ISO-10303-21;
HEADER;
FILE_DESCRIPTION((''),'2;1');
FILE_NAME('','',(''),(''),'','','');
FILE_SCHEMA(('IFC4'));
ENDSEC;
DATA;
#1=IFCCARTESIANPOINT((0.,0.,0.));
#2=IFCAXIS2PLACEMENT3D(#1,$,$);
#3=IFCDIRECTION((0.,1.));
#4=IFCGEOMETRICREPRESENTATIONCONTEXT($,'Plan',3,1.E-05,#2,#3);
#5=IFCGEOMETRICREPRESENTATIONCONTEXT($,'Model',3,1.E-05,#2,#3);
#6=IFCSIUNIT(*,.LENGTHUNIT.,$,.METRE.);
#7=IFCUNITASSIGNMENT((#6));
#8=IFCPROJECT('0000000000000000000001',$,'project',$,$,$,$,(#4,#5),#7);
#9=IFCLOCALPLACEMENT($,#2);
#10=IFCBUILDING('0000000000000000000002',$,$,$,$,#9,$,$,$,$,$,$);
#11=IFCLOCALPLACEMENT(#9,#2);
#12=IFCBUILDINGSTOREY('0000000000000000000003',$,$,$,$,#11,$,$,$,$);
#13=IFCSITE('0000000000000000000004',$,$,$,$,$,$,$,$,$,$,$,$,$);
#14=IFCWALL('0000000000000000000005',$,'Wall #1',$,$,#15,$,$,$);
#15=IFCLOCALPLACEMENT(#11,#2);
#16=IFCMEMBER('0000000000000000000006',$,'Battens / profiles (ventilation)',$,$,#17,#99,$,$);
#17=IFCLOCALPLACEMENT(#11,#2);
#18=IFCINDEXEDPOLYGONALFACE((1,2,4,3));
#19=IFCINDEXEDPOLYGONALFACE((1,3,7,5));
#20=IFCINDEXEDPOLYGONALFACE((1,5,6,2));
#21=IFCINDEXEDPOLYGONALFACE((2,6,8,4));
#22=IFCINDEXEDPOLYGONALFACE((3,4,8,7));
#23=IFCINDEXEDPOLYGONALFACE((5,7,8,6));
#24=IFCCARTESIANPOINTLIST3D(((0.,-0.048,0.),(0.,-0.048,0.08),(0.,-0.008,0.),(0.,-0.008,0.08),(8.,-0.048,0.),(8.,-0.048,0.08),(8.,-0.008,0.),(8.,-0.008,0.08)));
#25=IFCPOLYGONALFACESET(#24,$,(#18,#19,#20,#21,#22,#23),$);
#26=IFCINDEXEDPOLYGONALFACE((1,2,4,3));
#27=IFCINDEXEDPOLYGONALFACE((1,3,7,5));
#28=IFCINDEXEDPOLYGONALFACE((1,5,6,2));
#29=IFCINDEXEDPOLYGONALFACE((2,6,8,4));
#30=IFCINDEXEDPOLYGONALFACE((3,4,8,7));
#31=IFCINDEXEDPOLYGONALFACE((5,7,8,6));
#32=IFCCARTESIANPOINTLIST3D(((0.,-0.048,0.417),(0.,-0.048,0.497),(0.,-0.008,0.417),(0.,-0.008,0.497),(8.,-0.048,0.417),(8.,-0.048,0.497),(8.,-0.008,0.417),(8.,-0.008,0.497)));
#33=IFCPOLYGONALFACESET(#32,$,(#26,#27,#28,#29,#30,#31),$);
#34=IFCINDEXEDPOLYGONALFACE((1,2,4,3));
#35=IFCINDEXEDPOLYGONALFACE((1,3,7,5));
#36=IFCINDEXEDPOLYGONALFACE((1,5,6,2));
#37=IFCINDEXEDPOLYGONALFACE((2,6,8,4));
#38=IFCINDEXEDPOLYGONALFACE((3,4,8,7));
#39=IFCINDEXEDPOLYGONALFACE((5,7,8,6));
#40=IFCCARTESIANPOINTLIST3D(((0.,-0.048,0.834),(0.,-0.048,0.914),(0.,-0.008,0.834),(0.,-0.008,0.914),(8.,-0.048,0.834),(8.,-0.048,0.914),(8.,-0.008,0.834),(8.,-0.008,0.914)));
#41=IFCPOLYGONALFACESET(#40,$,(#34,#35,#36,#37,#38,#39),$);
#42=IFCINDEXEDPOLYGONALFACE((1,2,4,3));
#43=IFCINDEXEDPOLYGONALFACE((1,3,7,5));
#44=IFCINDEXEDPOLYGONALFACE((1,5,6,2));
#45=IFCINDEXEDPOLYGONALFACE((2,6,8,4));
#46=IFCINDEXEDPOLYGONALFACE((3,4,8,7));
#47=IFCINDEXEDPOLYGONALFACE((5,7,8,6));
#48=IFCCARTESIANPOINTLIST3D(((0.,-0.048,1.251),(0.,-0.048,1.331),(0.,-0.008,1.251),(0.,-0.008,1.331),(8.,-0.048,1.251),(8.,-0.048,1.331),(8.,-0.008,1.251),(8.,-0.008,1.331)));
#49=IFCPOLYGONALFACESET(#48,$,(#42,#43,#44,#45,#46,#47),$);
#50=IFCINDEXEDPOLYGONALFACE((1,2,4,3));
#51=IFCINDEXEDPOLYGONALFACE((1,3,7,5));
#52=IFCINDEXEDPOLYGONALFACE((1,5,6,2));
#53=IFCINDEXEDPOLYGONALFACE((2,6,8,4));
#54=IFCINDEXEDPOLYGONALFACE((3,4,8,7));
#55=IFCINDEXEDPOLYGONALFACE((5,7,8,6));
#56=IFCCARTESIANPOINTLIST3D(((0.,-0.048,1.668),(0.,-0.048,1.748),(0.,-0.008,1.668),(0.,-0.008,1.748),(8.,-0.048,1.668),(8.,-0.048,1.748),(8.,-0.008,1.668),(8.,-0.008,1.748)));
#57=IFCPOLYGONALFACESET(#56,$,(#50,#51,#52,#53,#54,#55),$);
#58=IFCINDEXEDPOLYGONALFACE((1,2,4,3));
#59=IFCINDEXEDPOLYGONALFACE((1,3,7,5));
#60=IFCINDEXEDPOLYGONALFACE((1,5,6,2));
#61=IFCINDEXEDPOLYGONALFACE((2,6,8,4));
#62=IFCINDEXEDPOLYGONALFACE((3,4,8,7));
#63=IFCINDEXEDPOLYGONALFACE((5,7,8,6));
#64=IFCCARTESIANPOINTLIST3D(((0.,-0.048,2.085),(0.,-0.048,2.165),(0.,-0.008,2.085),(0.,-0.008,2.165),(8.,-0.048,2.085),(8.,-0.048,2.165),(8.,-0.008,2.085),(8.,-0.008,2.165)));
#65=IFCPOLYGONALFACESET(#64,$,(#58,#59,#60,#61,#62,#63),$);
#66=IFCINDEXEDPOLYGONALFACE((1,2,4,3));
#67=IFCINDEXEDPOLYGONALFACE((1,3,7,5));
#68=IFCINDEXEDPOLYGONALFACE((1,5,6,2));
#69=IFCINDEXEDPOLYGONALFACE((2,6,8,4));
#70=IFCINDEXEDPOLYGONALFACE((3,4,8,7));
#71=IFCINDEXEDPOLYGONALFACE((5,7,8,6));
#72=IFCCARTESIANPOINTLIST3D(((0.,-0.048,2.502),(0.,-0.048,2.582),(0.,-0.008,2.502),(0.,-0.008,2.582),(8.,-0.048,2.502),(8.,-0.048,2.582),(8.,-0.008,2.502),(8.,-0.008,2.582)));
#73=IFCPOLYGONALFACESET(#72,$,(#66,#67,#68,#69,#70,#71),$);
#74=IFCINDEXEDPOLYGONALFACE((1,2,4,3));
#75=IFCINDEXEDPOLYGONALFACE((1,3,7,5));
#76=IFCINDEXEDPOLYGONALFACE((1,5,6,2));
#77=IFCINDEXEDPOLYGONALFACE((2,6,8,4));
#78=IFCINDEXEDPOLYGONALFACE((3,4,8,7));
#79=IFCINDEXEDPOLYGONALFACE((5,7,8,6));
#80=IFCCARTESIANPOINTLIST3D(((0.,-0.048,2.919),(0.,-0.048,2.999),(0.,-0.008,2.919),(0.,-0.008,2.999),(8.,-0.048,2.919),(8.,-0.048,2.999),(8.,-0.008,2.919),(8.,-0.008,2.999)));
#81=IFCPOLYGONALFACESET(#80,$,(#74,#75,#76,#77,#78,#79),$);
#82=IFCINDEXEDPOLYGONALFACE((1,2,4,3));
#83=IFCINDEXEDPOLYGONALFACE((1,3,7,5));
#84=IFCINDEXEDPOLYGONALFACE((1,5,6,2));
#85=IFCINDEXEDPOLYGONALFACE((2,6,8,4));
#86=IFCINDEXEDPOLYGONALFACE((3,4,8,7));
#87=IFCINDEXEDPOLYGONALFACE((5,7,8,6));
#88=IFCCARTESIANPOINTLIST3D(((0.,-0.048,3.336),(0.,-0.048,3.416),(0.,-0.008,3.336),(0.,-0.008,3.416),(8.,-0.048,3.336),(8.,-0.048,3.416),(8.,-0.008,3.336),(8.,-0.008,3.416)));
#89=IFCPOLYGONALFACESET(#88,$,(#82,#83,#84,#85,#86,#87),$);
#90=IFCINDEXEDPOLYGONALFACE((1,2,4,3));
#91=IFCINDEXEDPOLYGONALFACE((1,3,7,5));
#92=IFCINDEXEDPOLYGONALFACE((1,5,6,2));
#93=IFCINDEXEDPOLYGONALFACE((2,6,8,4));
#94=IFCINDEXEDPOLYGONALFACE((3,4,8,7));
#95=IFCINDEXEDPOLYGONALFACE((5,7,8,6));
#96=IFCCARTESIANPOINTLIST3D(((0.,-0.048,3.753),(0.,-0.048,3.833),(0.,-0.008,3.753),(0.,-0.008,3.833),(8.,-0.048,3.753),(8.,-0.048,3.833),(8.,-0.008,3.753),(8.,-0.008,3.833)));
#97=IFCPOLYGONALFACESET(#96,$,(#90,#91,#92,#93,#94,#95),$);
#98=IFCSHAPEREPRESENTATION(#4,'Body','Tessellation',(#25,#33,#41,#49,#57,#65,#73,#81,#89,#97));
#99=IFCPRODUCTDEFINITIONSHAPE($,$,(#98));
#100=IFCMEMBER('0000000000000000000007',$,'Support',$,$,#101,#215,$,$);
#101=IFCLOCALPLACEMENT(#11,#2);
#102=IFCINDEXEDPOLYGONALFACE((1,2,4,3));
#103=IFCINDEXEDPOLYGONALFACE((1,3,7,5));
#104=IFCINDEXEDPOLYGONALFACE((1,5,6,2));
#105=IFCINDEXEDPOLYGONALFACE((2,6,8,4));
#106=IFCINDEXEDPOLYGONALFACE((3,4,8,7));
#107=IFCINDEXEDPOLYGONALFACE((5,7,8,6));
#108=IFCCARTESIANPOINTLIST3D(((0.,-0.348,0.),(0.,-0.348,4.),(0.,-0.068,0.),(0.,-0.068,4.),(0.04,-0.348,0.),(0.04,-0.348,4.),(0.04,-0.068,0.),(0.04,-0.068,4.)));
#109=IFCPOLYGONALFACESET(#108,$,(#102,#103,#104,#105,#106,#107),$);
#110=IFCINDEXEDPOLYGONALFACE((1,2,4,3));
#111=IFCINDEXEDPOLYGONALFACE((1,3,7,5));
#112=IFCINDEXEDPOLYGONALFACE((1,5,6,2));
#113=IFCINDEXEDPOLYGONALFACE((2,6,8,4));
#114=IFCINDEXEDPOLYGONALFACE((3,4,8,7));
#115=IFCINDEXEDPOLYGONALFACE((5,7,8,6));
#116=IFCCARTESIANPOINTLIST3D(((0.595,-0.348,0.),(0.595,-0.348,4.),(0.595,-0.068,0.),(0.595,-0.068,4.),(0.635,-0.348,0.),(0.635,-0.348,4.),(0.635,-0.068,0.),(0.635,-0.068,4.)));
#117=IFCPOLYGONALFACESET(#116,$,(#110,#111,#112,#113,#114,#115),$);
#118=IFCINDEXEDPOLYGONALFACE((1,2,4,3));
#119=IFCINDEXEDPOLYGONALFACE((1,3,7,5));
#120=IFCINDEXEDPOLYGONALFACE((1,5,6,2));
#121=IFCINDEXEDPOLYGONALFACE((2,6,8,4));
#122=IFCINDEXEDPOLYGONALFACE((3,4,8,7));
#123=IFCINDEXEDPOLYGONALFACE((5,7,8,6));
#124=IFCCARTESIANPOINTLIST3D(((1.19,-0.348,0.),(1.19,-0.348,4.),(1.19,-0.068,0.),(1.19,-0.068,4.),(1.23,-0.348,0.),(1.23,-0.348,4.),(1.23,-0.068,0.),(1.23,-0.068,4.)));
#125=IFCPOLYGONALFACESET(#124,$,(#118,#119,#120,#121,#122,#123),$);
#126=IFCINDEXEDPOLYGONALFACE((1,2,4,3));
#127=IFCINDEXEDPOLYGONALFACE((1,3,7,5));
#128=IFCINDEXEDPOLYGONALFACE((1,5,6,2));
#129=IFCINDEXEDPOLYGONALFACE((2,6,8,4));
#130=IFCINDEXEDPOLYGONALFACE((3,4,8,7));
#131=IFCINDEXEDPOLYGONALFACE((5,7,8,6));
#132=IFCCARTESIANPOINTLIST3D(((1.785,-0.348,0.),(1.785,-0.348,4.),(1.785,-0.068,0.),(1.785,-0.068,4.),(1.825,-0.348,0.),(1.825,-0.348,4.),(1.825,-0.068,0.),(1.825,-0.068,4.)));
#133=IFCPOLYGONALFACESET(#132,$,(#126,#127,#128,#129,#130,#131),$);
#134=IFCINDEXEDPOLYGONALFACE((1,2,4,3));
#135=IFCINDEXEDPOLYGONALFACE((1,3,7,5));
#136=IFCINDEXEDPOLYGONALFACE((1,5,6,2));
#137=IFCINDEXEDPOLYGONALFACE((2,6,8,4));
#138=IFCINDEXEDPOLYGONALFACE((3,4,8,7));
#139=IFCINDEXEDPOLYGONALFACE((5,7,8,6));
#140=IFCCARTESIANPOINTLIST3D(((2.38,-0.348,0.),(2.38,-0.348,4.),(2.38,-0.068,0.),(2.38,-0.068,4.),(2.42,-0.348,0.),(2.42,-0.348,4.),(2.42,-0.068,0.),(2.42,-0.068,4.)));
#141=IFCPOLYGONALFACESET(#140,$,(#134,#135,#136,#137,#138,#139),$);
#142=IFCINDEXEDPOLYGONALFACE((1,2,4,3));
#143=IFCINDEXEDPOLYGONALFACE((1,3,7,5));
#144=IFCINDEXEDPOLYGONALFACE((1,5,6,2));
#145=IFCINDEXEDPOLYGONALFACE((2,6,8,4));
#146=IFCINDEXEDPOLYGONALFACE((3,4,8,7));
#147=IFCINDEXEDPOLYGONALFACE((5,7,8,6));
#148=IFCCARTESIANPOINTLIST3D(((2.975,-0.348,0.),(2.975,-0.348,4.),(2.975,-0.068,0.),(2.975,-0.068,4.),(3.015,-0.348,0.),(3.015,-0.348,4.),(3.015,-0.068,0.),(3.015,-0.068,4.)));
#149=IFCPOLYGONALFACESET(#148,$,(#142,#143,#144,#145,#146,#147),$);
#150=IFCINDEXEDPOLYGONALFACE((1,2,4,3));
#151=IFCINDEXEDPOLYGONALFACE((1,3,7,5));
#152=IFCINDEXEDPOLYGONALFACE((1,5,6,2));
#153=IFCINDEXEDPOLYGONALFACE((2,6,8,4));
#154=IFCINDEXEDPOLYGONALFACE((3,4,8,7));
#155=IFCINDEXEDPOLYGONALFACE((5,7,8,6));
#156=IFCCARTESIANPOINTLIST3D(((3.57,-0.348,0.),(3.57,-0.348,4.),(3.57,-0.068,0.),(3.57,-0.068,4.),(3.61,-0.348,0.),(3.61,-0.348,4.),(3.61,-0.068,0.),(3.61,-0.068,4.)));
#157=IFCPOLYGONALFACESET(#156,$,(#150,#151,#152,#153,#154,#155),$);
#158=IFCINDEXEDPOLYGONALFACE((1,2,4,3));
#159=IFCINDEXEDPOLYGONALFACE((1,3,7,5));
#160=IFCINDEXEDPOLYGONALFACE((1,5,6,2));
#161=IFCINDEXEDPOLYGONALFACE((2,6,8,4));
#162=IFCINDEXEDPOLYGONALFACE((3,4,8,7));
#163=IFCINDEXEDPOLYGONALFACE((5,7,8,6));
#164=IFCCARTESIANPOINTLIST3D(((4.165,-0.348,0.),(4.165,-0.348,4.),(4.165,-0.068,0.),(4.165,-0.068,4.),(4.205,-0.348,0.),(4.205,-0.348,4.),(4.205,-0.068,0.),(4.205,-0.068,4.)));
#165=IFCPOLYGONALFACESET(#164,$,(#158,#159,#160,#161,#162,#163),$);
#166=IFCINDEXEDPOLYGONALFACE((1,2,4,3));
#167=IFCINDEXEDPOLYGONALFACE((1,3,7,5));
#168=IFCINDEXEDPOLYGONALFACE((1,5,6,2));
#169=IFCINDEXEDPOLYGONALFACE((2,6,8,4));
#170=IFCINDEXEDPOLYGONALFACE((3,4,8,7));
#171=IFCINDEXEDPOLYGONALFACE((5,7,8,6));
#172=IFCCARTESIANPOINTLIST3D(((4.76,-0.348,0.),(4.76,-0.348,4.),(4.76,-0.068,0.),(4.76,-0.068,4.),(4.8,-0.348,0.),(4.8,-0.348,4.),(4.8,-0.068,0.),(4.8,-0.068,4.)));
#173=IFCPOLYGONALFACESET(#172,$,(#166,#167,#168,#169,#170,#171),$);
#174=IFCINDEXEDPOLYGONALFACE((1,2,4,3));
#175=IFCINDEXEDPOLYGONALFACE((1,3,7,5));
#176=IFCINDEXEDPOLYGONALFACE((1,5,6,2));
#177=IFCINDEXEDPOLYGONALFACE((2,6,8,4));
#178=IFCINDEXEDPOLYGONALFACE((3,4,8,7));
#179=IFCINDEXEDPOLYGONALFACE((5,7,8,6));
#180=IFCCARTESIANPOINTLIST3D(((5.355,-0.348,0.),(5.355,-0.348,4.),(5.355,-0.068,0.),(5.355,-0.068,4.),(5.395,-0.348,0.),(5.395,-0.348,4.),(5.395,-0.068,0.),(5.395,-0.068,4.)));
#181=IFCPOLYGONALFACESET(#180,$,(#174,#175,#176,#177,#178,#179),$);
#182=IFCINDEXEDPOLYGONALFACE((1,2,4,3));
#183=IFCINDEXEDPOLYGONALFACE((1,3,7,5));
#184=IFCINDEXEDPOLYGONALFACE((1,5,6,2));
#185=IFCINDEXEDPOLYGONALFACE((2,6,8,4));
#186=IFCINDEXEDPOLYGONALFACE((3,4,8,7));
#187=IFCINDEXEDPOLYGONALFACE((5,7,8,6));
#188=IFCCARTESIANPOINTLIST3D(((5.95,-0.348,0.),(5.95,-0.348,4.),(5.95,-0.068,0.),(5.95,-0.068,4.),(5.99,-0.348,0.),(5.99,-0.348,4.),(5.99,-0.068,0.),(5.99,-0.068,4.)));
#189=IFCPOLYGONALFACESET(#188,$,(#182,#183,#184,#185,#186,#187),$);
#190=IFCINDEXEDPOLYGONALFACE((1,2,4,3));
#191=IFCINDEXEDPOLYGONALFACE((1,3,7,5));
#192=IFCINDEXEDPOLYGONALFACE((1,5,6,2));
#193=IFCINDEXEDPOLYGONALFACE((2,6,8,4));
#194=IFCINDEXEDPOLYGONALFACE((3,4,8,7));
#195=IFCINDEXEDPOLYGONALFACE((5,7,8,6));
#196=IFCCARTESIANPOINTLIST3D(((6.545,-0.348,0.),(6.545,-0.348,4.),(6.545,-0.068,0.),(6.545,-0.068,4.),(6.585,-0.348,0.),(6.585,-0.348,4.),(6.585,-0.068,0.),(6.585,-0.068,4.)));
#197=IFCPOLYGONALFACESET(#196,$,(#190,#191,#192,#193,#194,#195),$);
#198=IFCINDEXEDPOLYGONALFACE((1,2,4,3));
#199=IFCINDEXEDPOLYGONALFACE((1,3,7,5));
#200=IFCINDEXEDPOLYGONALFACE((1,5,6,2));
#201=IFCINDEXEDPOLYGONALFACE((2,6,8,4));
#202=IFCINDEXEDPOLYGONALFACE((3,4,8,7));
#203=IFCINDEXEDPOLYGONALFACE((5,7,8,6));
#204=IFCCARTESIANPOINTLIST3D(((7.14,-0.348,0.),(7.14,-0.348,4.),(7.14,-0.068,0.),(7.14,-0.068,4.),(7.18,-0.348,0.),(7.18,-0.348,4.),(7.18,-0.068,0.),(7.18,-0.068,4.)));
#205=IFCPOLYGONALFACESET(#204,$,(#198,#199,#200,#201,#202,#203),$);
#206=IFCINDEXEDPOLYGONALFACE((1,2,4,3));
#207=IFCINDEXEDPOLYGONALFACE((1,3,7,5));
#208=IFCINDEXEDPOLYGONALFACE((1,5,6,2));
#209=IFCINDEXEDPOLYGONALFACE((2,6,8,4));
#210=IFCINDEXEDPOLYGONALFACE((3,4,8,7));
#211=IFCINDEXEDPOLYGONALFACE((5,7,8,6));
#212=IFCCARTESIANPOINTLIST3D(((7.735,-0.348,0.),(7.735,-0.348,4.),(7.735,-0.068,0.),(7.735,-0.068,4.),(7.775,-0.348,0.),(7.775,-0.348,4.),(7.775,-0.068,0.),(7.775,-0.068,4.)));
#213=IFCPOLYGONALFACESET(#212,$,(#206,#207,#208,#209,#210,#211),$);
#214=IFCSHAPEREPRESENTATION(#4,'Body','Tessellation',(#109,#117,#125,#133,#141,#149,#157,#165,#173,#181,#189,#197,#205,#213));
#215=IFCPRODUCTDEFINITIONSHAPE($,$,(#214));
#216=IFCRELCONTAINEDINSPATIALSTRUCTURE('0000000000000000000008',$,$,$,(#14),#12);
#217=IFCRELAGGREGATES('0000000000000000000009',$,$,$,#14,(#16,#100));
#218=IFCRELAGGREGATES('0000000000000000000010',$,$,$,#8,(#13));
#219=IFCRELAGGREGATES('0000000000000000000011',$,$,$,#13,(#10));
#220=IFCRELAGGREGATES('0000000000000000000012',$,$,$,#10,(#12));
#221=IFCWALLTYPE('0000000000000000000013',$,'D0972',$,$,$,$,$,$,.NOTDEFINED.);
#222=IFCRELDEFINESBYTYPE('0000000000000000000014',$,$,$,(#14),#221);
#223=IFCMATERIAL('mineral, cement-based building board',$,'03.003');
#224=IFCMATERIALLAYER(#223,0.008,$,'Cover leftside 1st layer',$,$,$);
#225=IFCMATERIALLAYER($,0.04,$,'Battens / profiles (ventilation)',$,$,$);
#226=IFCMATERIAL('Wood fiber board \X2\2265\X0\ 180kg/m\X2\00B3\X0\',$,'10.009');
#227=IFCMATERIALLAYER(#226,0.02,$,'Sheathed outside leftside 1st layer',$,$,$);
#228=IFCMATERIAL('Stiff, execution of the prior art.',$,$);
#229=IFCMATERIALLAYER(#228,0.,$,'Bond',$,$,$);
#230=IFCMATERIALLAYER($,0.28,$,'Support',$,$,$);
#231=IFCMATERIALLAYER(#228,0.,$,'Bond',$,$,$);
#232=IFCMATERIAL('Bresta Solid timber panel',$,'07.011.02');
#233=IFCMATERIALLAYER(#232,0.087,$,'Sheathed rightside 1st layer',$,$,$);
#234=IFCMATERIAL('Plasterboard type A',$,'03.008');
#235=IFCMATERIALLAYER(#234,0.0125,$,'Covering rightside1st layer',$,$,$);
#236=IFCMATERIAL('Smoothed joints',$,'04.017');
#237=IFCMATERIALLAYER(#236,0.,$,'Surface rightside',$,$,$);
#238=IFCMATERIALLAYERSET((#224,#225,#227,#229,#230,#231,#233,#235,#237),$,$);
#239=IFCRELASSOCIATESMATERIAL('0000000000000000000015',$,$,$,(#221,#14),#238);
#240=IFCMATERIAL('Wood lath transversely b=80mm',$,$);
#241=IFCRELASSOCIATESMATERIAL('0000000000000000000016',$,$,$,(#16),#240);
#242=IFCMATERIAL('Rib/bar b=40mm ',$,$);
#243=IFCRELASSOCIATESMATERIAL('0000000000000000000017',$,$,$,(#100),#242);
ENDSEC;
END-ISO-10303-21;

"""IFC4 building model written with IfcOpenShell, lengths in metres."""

from ifc_helpers import new_model, si_unit, direction, frame, frame_2d, origin, place, context, project, spatial, rectangle, extrude, material, layer, layer_set, type_object, element, aggregate, save


model = new_model("IFC4")

# Units and contexts
plan_context = context("Plan", 3, precision=1e-05, world=origin(), true_north=direction((0.0, 1.0)))
model_context = context("Model", 3, precision=1e-05, world=origin(), true_north=direction((0.0, 1.0)))
ifc_project = project(units=[si_unit("LENGTHUNIT", "METRE")], contexts=[plan_context, model_context])

# Site, building, storey
site = spatial("IfcSite", under=ifc_project)
building_placement = place(None, origin())
building = spatial("IfcBuilding", under=site, at=building_placement)
storey_placement = place(building_placement, origin())
storey = spatial("IfcBuildingStorey", under=building, at=storey_placement)

# Wall, members
ifc_material_1 = material(Name="mineral, cement-based building board", Category="03.003")
ifc_layer_1 = layer(ifc_material_1, 0.008, Name="Cover leftside 1st layer")
ifc_layer_2 = layer(None, 0.04, Name="Battens / profiles (ventilation)")
ifc_material_2 = material(Name="Wood fiber board ≥ 180kg/m³", Category="10.009")
ifc_layer_3 = layer(ifc_material_2, 0.02, Name="Sheathed outside leftside 1st layer")
ifc_material_3 = material(Name="Stiff, execution of the prior art.")
ifc_layer_4 = layer(ifc_material_3, 0.0, Name="Bond")
ifc_layer_5 = layer(None, 0.28, Name="Support")
ifc_layer_6 = layer(ifc_material_3, 0.0, Name="Bond")
ifc_material_4 = material(Name="Bresta Solid timber panel", Category="07.011.02")
ifc_layer_7 = layer(ifc_material_4, 0.087, Name="Sheathed rightside 1st layer")
ifc_material_5 = material(Name="Plasterboard type A", Category="03.008")
ifc_layer_8 = layer(ifc_material_5, 0.0125, Name="Covering rightside1st layer")
ifc_material_6 = material(Name="Smoothed joints", Category="04.017")
ifc_layer_9 = layer(ifc_material_6, 0.0, Name="Surface rightside")
ifc_layer_set = layer_set([ifc_layer_1, ifc_layer_2, ifc_layer_3, ifc_layer_4, ifc_layer_5, ifc_layer_6, ifc_layer_7, ifc_layer_8, ifc_layer_9])
wall_type = type_object("IfcWallType", Name="D0972", PredefinedType="NOTDEFINED", material=ifc_layer_set)
wall_placement = place(None, frame((0.0, 0.0, 0.0), z_axis=(0.0, -1.0, 0.0), x_axis=(1.0, 0.0, 0.0)))
wall = element("IfcWall", 1, at=wall_placement, inside=storey, type_object=wall_type, material=ifc_layer_set, Name="Wall #1")
ifc_material_7 = material(Name="Wood lath transversely b=80mm")
member_1_placement = place(wall_placement, origin())
member_1 = element("IfcMember", 2, at=member_1_placement, material=ifc_material_7, Name="Battens / profiles (ventilation)", context=plan_context, shape_type="SweptSolid", body=[
    extrude(rectangle(XDim=0.08, YDim=0.04, at=frame_2d((0.04, 0.02), x_axis=(1.0, 0.0))), frame((0.0, 0.0, 0.008), z_axis=(1.0, 0.0, 0.0), x_axis=(0.0, 1.0, 0.0)), (0.0, 0.0, 1.0), 8.0),
    extrude(rectangle(XDim=0.08, YDim=0.04, at=frame_2d((0.04, 0.02), x_axis=(1.0, 0.0))), frame((0.0, 0.417, 0.008), z_axis=(1.0, 0.0, 0.0), x_axis=(0.0, 1.0, 0.0)), (0.0, 0.0, 1.0), 8.0),
    extrude(rectangle(XDim=0.08, YDim=0.04, at=frame_2d((0.04, 0.02), x_axis=(1.0, 0.0))), frame((0.0, 0.834, 0.008), z_axis=(1.0, 0.0, 0.0), x_axis=(0.0, 1.0, 0.0)), (0.0, 0.0, 1.0), 8.0),
    extrude(rectangle(XDim=0.08, YDim=0.04, at=frame_2d((0.04, 0.02), x_axis=(1.0, 0.0))), frame((0.0, 1.251, 0.008), z_axis=(1.0, 0.0, 0.0), x_axis=(0.0, 1.0, 0.0)), (0.0, 0.0, 1.0), 8.0),
    extrude(rectangle(XDim=0.08, YDim=0.04, at=frame_2d((0.04, 0.02), x_axis=(1.0, 0.0))), frame((0.0, 1.668, 0.008), z_axis=(1.0, 0.0, 0.0), x_axis=(0.0, 1.0, 0.0)), (0.0, 0.0, 1.0), 8.0),
    extrude(rectangle(XDim=0.08, YDim=0.04, at=frame_2d((0.04, 0.02), x_axis=(1.0, 0.0))), frame((0.0, 2.085, 0.008), z_axis=(1.0, 0.0, 0.0), x_axis=(0.0, 1.0, 0.0)), (0.0, 0.0, 1.0), 8.0),
    extrude(rectangle(XDim=0.08, YDim=0.04, at=frame_2d((0.04, 0.02), x_axis=(1.0, 0.0))), frame((0.0, 2.502, 0.008), z_axis=(1.0, 0.0, 0.0), x_axis=(0.0, 1.0, 0.0)), (0.0, 0.0, 1.0), 8.0),
    extrude(rectangle(XDim=0.08, YDim=0.04, at=frame_2d((0.04, 0.02), x_axis=(1.0, 0.0))), frame((0.0, 2.919, 0.008), z_axis=(1.0, 0.0, 0.0), x_axis=(0.0, 1.0, 0.0)), (0.0, 0.0, 1.0), 8.0),
    extrude(rectangle(XDim=0.08, YDim=0.04, at=frame_2d((0.04, 0.02), x_axis=(1.0, 0.0))), frame((0.0, 3.336, 0.008), z_axis=(1.0, 0.0, 0.0), x_axis=(0.0, 1.0, 0.0)), (0.0, 0.0, 1.0), 8.0),
    extrude(rectangle(XDim=0.08, YDim=0.04, at=frame_2d((0.04, 0.02), x_axis=(1.0, 0.0))), frame((0.0, 3.753, 0.008), z_axis=(1.0, 0.0, 0.0), x_axis=(0.0, 1.0, 0.0)), (0.0, 0.0, 1.0), 8.0),
])
ifc_material_8 = material(Name="Rib/bar b=40mm ")
member_2_placement = place(wall_placement, origin())
member_2 = element("IfcMember", 3, at=member_2_placement, material=ifc_material_8, Name="Support", context=plan_context, shape_type="SweptSolid", body=[
    extrude(rectangle(XDim=0.04, YDim=0.28, at=frame_2d((0.02, 0.14), x_axis=(1.0, 0.0))), frame((0.0, 4.0, 0.068), z_axis=(0.0, -1.0, 0.0), x_axis=(1.0, 0.0, 0.0)), (0.0, 0.0, 1.0), 4.0),
    extrude(rectangle(XDim=0.04, YDim=0.28, at=frame_2d((0.02, 0.14), x_axis=(1.0, 0.0))), frame((0.595, 4.0, 0.068), z_axis=(0.0, -1.0, 0.0), x_axis=(1.0, 0.0, 0.0)), (0.0, 0.0, 1.0), 4.0),
    extrude(rectangle(XDim=0.04, YDim=0.28, at=frame_2d((0.02, 0.14), x_axis=(1.0, 0.0))), frame((1.19, 4.0, 0.068), z_axis=(0.0, -1.0, 0.0), x_axis=(1.0, 0.0, 0.0)), (0.0, 0.0, 1.0), 4.0),
    extrude(rectangle(XDim=0.04, YDim=0.28, at=frame_2d((0.02, 0.14), x_axis=(1.0, 0.0))), frame((1.785, 4.0, 0.068), z_axis=(0.0, -1.0, 0.0), x_axis=(1.0, 0.0, 0.0)), (0.0, 0.0, 1.0), 4.0),
    extrude(rectangle(XDim=0.04, YDim=0.28, at=frame_2d((0.02, 0.14), x_axis=(1.0, 0.0))), frame((2.38, 4.0, 0.068), z_axis=(0.0, -1.0, 0.0), x_axis=(1.0, 0.0, 0.0)), (0.0, 0.0, 1.0), 4.0),
    extrude(rectangle(XDim=0.04, YDim=0.28, at=frame_2d((0.02, 0.14), x_axis=(1.0, 0.0))), frame((2.975, 4.0, 0.068), z_axis=(0.0, -1.0, 0.0), x_axis=(1.0, 0.0, 0.0)), (0.0, 0.0, 1.0), 4.0),
    extrude(rectangle(XDim=0.04, YDim=0.28, at=frame_2d((0.02, 0.14), x_axis=(1.0, 0.0))), frame((3.57, 4.0, 0.068), z_axis=(0.0, -1.0, 0.0), x_axis=(1.0, 0.0, 0.0)), (0.0, 0.0, 1.0), 4.0),
    extrude(rectangle(XDim=0.04, YDim=0.28, at=frame_2d((0.02, 0.14), x_axis=(1.0, 0.0))), frame((4.165, 4.0, 0.068), z_axis=(0.0, -1.0, 0.0), x_axis=(1.0, 0.0, 0.0)), (0.0, 0.0, 1.0), 4.0),
    extrude(rectangle(XDim=0.04, YDim=0.28, at=frame_2d((0.02, 0.14), x_axis=(1.0, 0.0))), frame((4.76, 4.0, 0.068), z_axis=(0.0, -1.0, 0.0), x_axis=(1.0, 0.0, 0.0)), (0.0, 0.0, 1.0), 4.0),
    extrude(rectangle(XDim=0.04, YDim=0.28, at=frame_2d((0.02, 0.14), x_axis=(1.0, 0.0))), frame((5.355, 4.0, 0.068), z_axis=(0.0, -1.0, 0.0), x_axis=(1.0, 0.0, 0.0)), (0.0, 0.0, 1.0), 4.0),
    extrude(rectangle(XDim=0.04, YDim=0.28, at=frame_2d((0.02, 0.14), x_axis=(1.0, 0.0))), frame((5.95, 4.0, 0.068), z_axis=(0.0, -1.0, 0.0), x_axis=(1.0, 0.0, 0.0)), (0.0, 0.0, 1.0), 4.0),
    extrude(rectangle(XDim=0.04, YDim=0.28, at=frame_2d((0.02, 0.14), x_axis=(1.0, 0.0))), frame((6.545, 4.0, 0.068), z_axis=(0.0, -1.0, 0.0), x_axis=(1.0, 0.0, 0.0)), (0.0, 0.0, 1.0), 4.0),
    extrude(rectangle(XDim=0.04, YDim=0.28, at=frame_2d((0.02, 0.14), x_axis=(1.0, 0.0))), frame((7.14, 4.0, 0.068), z_axis=(0.0, -1.0, 0.0), x_axis=(1.0, 0.0, 0.0)), (0.0, 0.0, 1.0), 4.0),
    extrude(rectangle(XDim=0.04, YDim=0.28, at=frame_2d((0.02, 0.14), x_axis=(1.0, 0.0))), frame((7.735, 4.0, 0.068), z_axis=(0.0, -1.0, 0.0), x_axis=(1.0, 0.0, 0.0)), (0.0, 0.0, 1.0), 4.0),
])
aggregate(wall, [member_1, member_2])

save(model, "model.ifc")
